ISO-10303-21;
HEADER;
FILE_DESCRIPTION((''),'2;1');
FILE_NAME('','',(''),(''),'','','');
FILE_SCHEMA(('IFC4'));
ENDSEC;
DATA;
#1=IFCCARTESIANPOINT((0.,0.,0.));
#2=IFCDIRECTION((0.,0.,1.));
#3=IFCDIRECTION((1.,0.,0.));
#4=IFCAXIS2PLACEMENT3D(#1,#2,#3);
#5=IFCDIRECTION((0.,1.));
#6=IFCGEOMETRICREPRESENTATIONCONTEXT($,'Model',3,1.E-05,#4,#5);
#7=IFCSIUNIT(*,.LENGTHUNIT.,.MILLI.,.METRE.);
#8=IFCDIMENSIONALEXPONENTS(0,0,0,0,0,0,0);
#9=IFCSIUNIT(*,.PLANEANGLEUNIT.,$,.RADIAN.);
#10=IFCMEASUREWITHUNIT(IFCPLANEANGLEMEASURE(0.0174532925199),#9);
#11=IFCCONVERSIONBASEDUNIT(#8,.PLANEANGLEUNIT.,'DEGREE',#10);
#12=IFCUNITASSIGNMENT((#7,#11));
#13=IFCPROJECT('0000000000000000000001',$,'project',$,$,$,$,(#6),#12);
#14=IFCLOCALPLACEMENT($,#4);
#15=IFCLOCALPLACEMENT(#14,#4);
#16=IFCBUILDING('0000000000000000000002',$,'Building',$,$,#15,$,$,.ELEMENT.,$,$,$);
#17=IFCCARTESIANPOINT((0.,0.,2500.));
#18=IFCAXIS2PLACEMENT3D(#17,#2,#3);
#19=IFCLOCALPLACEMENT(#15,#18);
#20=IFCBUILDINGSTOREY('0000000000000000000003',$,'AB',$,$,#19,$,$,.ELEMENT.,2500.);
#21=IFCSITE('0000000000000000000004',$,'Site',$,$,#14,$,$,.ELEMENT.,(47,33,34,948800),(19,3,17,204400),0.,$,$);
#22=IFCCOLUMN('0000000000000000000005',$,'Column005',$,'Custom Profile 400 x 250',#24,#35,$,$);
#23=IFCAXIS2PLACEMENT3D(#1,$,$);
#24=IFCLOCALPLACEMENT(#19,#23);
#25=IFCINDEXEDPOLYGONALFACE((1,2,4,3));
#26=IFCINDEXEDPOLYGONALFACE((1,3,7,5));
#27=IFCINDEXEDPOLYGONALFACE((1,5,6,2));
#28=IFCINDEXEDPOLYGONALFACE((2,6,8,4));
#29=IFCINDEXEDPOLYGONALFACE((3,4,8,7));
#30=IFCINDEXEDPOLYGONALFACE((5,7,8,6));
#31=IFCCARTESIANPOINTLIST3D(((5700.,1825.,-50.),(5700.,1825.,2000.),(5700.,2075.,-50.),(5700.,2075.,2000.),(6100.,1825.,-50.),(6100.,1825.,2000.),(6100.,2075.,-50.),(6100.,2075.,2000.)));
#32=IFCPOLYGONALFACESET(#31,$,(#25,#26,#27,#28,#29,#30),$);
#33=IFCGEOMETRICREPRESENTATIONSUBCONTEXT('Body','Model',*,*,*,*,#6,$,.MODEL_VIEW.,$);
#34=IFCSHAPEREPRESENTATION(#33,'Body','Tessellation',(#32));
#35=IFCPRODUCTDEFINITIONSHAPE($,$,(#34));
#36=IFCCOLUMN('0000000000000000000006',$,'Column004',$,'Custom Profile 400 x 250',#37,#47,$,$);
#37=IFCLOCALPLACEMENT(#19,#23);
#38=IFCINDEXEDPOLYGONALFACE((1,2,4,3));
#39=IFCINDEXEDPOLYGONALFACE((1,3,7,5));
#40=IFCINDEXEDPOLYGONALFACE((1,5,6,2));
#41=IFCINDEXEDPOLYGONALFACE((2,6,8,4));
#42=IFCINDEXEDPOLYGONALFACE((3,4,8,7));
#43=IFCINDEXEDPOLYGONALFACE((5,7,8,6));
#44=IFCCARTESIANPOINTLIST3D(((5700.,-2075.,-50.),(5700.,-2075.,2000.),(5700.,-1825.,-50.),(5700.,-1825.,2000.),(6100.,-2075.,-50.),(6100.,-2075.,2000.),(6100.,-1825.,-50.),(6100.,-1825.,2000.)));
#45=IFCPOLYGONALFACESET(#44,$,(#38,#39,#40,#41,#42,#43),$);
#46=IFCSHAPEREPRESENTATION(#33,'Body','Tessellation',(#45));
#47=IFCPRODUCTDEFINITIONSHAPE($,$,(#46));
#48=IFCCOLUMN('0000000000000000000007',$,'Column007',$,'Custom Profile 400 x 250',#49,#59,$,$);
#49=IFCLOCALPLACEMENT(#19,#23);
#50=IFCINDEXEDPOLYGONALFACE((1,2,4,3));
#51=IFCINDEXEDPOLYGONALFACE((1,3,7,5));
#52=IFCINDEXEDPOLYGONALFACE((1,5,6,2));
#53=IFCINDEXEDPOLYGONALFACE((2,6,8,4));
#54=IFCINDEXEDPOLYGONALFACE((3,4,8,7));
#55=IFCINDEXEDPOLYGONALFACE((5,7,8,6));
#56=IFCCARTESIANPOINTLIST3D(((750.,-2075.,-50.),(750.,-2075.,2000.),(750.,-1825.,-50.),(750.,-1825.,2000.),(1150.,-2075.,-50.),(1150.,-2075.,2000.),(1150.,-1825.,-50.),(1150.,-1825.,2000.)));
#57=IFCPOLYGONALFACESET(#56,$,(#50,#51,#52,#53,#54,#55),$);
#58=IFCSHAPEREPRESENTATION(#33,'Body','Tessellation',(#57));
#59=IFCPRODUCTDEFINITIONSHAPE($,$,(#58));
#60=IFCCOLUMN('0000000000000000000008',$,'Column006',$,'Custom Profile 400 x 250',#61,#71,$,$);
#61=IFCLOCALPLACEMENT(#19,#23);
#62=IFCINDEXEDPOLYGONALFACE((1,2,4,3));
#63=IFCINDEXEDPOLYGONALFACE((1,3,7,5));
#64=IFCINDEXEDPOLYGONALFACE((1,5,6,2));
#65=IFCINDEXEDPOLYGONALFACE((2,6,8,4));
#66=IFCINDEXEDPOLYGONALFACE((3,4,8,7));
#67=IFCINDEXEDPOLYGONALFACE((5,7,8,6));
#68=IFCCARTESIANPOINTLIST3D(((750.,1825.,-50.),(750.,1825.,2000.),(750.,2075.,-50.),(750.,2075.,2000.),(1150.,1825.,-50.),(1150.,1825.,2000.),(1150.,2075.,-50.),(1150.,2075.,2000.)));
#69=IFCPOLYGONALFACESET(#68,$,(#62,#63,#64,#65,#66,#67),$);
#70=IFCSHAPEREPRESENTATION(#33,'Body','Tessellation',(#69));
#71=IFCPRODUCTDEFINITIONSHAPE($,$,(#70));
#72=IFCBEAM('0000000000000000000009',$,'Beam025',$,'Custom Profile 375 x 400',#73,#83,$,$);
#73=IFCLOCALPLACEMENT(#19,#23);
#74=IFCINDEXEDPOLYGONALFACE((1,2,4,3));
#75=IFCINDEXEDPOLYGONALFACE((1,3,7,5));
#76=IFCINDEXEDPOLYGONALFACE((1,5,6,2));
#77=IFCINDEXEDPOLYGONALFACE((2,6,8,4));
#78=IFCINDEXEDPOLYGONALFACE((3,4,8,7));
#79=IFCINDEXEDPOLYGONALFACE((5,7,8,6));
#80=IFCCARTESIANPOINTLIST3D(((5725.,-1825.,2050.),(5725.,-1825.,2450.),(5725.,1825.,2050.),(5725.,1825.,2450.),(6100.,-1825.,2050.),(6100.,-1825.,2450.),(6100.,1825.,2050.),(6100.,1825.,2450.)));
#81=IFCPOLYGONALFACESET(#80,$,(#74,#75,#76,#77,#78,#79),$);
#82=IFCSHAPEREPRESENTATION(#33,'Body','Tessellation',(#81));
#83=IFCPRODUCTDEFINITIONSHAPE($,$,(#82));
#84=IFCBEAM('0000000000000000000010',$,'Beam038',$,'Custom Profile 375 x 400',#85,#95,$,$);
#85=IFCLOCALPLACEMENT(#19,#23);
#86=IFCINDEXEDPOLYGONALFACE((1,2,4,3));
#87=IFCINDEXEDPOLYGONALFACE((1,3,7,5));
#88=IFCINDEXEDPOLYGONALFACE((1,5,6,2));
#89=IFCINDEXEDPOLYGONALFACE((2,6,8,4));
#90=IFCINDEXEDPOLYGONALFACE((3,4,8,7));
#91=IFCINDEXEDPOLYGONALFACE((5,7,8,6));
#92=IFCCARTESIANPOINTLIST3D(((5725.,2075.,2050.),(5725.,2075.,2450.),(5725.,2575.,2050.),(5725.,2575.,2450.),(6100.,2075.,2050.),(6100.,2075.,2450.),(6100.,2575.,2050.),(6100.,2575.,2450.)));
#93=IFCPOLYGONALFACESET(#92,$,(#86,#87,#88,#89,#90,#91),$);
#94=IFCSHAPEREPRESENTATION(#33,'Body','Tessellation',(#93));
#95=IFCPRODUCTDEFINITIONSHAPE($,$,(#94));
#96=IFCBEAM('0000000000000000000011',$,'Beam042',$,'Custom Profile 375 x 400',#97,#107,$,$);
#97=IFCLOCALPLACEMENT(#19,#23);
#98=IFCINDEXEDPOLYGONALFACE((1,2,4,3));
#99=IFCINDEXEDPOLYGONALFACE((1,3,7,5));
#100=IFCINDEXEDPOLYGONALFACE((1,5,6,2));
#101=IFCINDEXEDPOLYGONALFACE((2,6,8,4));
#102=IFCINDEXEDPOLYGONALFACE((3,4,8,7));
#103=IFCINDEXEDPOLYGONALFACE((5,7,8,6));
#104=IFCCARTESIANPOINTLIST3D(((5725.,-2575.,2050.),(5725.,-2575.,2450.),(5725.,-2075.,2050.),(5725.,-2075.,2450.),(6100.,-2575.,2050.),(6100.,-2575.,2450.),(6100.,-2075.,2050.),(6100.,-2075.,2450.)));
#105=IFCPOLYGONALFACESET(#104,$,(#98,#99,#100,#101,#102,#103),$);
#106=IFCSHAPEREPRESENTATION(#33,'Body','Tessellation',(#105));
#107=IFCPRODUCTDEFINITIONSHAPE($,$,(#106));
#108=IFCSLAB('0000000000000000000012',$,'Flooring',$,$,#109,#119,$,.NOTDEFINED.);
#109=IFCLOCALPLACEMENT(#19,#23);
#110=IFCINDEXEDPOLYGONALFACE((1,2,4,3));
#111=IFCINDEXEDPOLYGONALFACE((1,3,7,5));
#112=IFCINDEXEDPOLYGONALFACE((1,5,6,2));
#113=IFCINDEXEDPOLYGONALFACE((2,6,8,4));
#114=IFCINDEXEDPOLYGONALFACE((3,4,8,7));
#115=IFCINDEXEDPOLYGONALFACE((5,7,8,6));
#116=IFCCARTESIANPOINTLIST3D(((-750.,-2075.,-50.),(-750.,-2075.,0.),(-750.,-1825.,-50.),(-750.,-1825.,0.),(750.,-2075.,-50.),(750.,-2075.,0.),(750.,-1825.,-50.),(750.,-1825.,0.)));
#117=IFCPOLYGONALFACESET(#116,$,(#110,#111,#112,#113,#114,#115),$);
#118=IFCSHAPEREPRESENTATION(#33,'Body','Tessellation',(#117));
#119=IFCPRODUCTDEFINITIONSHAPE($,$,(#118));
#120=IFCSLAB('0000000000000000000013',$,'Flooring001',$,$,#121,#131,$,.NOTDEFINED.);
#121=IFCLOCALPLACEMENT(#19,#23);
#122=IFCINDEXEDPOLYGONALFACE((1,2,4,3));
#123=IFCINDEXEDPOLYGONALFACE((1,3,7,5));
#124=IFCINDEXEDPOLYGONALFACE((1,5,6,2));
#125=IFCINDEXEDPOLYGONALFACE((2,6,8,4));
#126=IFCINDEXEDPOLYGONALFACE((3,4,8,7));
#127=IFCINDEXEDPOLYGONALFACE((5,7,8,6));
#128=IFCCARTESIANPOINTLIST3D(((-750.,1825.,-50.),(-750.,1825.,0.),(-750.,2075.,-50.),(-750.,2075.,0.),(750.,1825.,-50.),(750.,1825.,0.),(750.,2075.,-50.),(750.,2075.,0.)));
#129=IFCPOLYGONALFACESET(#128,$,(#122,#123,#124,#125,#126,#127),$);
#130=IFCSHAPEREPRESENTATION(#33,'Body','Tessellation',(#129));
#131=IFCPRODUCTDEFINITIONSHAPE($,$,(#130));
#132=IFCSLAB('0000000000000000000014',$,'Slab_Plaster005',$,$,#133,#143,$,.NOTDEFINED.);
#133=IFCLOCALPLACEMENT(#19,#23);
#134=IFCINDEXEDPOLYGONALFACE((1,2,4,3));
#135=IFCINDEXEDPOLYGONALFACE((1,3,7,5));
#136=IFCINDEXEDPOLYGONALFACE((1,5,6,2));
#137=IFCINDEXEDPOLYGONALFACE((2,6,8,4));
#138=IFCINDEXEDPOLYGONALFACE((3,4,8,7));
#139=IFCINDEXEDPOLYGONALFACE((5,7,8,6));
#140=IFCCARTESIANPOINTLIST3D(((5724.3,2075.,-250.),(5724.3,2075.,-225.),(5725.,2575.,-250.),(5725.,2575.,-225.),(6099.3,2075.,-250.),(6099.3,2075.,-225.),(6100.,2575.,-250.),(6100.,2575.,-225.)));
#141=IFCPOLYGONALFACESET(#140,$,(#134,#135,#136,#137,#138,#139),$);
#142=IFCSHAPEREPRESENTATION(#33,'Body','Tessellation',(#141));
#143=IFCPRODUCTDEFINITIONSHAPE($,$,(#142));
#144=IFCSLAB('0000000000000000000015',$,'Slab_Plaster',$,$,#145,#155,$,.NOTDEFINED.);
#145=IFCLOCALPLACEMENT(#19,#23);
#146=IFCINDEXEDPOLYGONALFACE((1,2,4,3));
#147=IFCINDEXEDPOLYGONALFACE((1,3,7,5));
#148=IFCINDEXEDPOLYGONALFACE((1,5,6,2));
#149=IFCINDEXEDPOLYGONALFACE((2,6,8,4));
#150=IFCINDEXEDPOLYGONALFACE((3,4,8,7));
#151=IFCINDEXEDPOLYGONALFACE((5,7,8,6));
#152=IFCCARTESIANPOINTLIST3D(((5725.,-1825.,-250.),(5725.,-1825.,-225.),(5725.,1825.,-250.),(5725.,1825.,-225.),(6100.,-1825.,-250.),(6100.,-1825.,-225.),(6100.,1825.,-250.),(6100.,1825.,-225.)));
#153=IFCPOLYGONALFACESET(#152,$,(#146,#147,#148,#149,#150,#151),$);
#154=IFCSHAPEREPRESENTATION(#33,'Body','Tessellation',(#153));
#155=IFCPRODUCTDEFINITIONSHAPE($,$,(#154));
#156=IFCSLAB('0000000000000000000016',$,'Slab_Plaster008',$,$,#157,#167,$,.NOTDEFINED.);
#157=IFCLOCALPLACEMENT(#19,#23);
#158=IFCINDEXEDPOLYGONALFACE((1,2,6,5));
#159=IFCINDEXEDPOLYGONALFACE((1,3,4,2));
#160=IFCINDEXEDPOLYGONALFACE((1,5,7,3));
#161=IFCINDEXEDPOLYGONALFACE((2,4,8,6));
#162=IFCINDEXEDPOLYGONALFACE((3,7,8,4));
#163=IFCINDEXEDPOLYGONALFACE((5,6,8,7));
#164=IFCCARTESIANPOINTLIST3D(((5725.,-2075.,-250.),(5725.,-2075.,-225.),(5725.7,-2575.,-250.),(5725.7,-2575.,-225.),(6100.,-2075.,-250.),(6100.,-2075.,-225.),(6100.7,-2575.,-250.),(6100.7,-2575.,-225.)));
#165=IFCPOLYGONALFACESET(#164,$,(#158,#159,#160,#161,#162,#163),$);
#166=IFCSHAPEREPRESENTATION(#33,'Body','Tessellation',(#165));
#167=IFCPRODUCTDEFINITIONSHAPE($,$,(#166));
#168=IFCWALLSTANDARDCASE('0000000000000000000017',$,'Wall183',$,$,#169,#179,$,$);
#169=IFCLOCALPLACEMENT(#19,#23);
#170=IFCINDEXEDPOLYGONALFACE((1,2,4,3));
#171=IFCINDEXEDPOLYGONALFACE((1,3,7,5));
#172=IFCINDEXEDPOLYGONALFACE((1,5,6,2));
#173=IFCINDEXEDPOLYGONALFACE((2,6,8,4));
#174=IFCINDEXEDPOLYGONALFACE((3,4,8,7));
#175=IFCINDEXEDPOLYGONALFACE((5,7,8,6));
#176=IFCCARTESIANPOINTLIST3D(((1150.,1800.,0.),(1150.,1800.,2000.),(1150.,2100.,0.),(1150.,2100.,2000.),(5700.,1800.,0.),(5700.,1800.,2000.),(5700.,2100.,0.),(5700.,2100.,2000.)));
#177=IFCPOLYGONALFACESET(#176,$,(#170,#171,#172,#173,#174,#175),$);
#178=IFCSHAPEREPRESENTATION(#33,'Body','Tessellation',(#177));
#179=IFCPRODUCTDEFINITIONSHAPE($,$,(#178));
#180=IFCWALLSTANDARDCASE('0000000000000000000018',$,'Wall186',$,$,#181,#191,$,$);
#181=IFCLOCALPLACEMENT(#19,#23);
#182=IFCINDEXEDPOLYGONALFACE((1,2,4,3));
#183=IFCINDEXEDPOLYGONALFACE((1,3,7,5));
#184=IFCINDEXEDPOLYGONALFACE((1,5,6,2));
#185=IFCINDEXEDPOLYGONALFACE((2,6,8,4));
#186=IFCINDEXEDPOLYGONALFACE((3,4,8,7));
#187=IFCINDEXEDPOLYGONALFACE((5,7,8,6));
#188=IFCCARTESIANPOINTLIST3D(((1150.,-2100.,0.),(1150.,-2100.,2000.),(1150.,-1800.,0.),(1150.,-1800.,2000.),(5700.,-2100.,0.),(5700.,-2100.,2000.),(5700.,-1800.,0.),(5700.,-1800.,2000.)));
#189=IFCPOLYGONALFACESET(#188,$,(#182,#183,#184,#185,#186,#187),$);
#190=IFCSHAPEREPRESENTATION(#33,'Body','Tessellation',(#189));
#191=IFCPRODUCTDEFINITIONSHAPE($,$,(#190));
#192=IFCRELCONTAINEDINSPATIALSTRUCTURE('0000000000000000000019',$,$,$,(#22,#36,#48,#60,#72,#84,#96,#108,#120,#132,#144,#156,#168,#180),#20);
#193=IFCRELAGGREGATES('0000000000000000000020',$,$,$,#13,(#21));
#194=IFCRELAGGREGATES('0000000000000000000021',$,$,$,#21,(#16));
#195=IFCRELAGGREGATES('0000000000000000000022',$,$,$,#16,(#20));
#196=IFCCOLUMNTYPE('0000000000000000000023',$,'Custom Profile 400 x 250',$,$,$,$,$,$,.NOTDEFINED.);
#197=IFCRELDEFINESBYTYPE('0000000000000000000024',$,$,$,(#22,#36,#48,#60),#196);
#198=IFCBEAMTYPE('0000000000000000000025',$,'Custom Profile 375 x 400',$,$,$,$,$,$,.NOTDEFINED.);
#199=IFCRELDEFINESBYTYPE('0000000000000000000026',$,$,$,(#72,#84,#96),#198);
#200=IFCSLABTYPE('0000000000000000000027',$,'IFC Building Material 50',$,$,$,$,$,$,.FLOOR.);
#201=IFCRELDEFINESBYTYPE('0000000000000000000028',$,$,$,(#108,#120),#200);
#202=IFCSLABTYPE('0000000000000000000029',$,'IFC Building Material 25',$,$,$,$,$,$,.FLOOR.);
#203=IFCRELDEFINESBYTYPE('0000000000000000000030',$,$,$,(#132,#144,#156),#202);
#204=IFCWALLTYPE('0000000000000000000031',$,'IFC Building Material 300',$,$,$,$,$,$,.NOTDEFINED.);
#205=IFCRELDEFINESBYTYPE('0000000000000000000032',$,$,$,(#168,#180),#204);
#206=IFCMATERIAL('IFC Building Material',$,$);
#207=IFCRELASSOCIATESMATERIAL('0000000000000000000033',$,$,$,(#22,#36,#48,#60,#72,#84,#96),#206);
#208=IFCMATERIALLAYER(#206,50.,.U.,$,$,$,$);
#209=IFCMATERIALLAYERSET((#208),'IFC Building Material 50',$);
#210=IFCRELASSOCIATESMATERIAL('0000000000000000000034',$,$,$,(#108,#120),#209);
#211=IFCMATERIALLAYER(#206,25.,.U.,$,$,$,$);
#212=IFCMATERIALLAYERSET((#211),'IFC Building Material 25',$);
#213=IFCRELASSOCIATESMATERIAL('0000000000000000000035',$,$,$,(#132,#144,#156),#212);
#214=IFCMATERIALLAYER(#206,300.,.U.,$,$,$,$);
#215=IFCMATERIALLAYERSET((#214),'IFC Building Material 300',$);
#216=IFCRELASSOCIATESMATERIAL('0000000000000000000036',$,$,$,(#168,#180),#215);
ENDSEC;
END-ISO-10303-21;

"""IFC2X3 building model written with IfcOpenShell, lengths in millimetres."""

from ifc_helpers import new_model, entity, si_unit, converted_unit, direction, frame, origin_with_axes, place, context, subcontext, project, spatial, polyline, outline, extrude, material, layer, layer_set, layer_usage, type_object, element, save


model = new_model("IFC2X3")

# Units and contexts
model_context = context("Model", 3, precision=1e-05, world=origin_with_axes(), true_north=direction((0.0, 1.0)))
body_context = subcontext(model_context, "Body", "Model", "MODEL_VIEW")
ifc_project = project(units=[si_unit("LENGTHUNIT", "METRE", prefix="MILLI"), converted_unit("PLANEANGLEUNIT", "DEGREE", entity("IfcPlaneAngleMeasure", 0.0174532925199), si_unit("PLANEANGLEUNIT", "RADIAN"), dimensions=[0, 0, 0, 0, 0, 0, 0])], contexts=[model_context])

# Site, building, storey
site_placement = place(None, origin_with_axes())
site = spatial("IfcSite", under=ifc_project, at=site_placement, Name="Site", CompositionType="ELEMENT", RefLatitude=(47, 33, 34, 948800), RefLongitude=(19, 3, 17, 204400), RefElevation=0.0)
building_placement = place(site_placement, origin_with_axes())
building = spatial("IfcBuilding", under=site, at=building_placement, Name="Building", CompositionType="ELEMENT")
storey_placement = place(building_placement, frame((0.0, 0.0, 2500.0), z_axis=(0.0, 0.0, 1.0), x_axis=(1.0, 0.0, 0.0)))
storey = spatial("IfcBuildingStorey", under=building, at=storey_placement, Name="AB", CompositionType="ELEMENT", Elevation=2500.0)

# Columns
ifc_material = material(Name="IFC Building Material")
column_type = type_object("IfcColumnType", Name="Custom Profile 400 x 250", PredefinedType="NOTDEFINED")
for number, where, z_axis, x_axis, name in (
    (1, (5900.0, 1950.0, -50.0), (0.0, 0.0, 1.0), (1.0, 0.0, 0.0), "Column005"),
    (2, (5900.0, -1950.0, -50.0), (0.0, 0.0, 1.0), (1.0, 0.0, 0.0), "Column004"),
    (3, (950.0, -1950.0, -50.0), (0.0, 0.0, 1.0), (1.0, 0.0, 0.0), "Column007"),
    (4, (950.0, 1950.0, -50.0), (0.0, 0.0, 1.0), (1.0, 0.0, 0.0), "Column006"),
):
    element("IfcColumn", number, at=place(storey_placement, frame(where, z_axis=z_axis, x_axis=x_axis)), inside=storey, type_object=column_type, material=ifc_material, Name=name, ObjectType="Custom Profile 400 x 250", context=body_context, shape_type="SweptSolid", body=[
        extrude(outline(polyline([(-200.0, -125.0), (200.0, -125.0), (200.0, 125.0), (-200.0, 125.0), (-200.0, -125.0)])), origin_with_axes(), (0.0, 0.0, 1.0), 2050.0),
    ])

# Beams
beam_type = type_object("IfcBeamType", Name="Custom Profile 375 x 400", PredefinedType="NOTDEFINED")
beam_placement = place(storey_placement, frame((5912.5, -1825.0, 2250.0), z_axis=(0.0, 0.0, 1.0), x_axis=(1.0, 0.0, 0.0)))
element("IfcBeam", 5, at=beam_placement, inside=storey, type_object=beam_type, material=ifc_material, Name="Beam025", ObjectType="Custom Profile 375 x 400", context=body_context, shape_type="SweptSolid", body=[
    extrude(outline(polyline([(-187.5, -200.0), (187.5, -200.0), (187.5, 200.0), (-187.5, 200.0), (-187.5, -200.0)])), frame((0.0, 3650.0, 0.0), z_axis=(0.0, -1.0, 0.0), x_axis=(1.0, 0.0, 0.0)), (0.0, 0.0, 1.0), 3650.0),
])
for number, where, z_axis, x_axis, name in (
    (6, (5912.5, 2575.0, 2250.0), (0.0, 0.0, 1.0), (-1.0, 0.0, 0.0), "Beam038"),
    (7, (5912.5, -2075.0, 2250.0), (0.0, 0.0, 1.0), (-1.0, 0.0, 0.0), "Beam042"),
):
    element("IfcBeam", number, at=place(storey_placement, frame(where, z_axis=z_axis, x_axis=x_axis)), inside=storey, type_object=beam_type, material=ifc_material, Name=name, ObjectType="Custom Profile 375 x 400", context=body_context, shape_type="SweptSolid", body=[
        extrude(outline(polyline([(187.5, 200.0), (-187.5, 200.0), (-187.5, -200.0), (187.5, -200.0), (187.5, 200.0)])), frame((0.0, 500.0, 0.0), z_axis=(0.0, -1.0, 0.0), x_axis=(1.0, 0.0, 0.0)), (0.0, 0.0, 1.0), 500.0),
    ])

# Slabs
ifc_layer_1 = layer(ifc_material, 50.0, ventilated="UNKNOWN")
ifc_layer_set_1 = layer_set([ifc_layer_1], Name="IFC Building Material 50")
ifc_layer_usage_1 = layer_usage(ifc_layer_set_1, "AXIS3", "NEGATIVE", 50.0)
slab_type_1 = type_object("IfcSlabType", Name="IFC Building Material 50", PredefinedType="FLOOR")
slab_1_placement = place(storey_placement, frame((-750.0, -2075.0, 0.0), z_axis=(0.0, 0.0, 1.0), x_axis=(1.0, 0.0, 0.0)))
element("IfcSlab", 8, at=slab_1_placement, inside=storey, type_object=slab_type_1, material=ifc_layer_usage_1, Name="Flooring", PredefinedType="NOTDEFINED", context=body_context, shape_type="SweptSolid", body=[
    extrude(outline(polyline([(0.0, 0.0), (1500.0, 0.0), (1500.0, 250.0), (0.0, 250.0), (0.0, 0.0)])), frame((0.0, 0.0, -50.0), z_axis=(0.0, 0.0, 1.0), x_axis=(1.0, 0.0, 0.0)), (0.0, 0.0, 1.0), 50.0),
])
ifc_layer_usage_2 = layer_usage(ifc_layer_set_1, "AXIS3", "NEGATIVE", 50.0)
slab_2_placement = place(storey_placement, frame((-750.0, 1825.0, 0.0), z_axis=(0.0, 0.0, 1.0), x_axis=(1.0, 0.0, 0.0)))
element("IfcSlab", 9, at=slab_2_placement, inside=storey, type_object=slab_type_1, material=ifc_layer_usage_2, Name="Flooring001", PredefinedType="NOTDEFINED", context=body_context, shape_type="SweptSolid", body=[
    extrude(outline(polyline([(0.0, 0.0), (1500.0, 0.0), (1500.0, 250.0), (0.0, 250.0), (0.0, 0.0)])), frame((0.0, 0.0, -50.0), z_axis=(0.0, 0.0, 1.0), x_axis=(1.0, 0.0, 0.0)), (0.0, 0.0, 1.0), 50.0),
])
ifc_layer_2 = layer(ifc_material, 25.0, ventilated="UNKNOWN")
ifc_layer_set_2 = layer_set([ifc_layer_2], Name="IFC Building Material 25")
ifc_layer_usage_3 = layer_usage(ifc_layer_set_2, "AXIS3", "NEGATIVE", 25.0)
slab_type_2 = type_object("IfcSlabType", Name="IFC Building Material 25", PredefinedType="FLOOR")
slab_3_placement = place(storey_placement, frame((6099.3, 2075.0, -225.0), z_axis=(0.0, 0.0, 1.0), x_axis=(1.0, 0.0, 0.0)))
element("IfcSlab", 10, at=slab_3_placement, inside=storey, type_object=slab_type_2, material=ifc_layer_usage_3, Name="Slab_Plaster005", PredefinedType="NOTDEFINED", context=body_context, shape_type="SweptSolid", body=[
    extrude(outline(polyline([(0.0, 0.0), (0.7, 500.0), (-374.3, 500.0), (-375.0, 0.0), (0.0, 0.0)])), frame((0.0, 0.0, -25.0), z_axis=(0.0, 0.0, 1.0), x_axis=(1.0, 0.0, 0.0)), (0.0, 0.0, 1.0), 25.0),
])
ifc_layer_usage_4 = layer_usage(ifc_layer_set_2, "AXIS3", "NEGATIVE", 25.0)
slab_4_placement = place(storey_placement, frame((6100.0, -1825.0, -225.0), z_axis=(0.0, 0.0, 1.0), x_axis=(1.0, 0.0, 0.0)))
element("IfcSlab", 11, at=slab_4_placement, inside=storey, type_object=slab_type_2, material=ifc_layer_usage_4, Name="Slab_Plaster", PredefinedType="NOTDEFINED", context=body_context, shape_type="SweptSolid", body=[
    extrude(outline(polyline([(0.0, 0.0), (0.0, 3650.0), (-375.0, 3650.0), (-375.0, 0.0), (0.0, 0.0)])), frame((0.0, 0.0, -25.0), z_axis=(0.0, 0.0, 1.0), x_axis=(1.0, 0.0, 0.0)), (0.0, 0.0, 1.0), 25.0),
])
ifc_layer_usage_5 = layer_usage(ifc_layer_set_2, "AXIS3", "NEGATIVE", 25.0)
slab_5_placement = place(storey_placement, frame((6100.0, -2075.0, -225.0), z_axis=(0.0, 0.0, 1.0), x_axis=(1.0, 0.0, 0.0)))
element("IfcSlab", 12, at=slab_5_placement, inside=storey, type_object=slab_type_2, material=ifc_layer_usage_5, Name="Slab_Plaster008", PredefinedType="NOTDEFINED", context=body_context, shape_type="SweptSolid", body=[
    extrude(outline(polyline([(0.0, 0.0), (-375.0, 0.0), (-374.3, -500.0), (0.7, -500.0), (0.0, 0.0)])), frame((0.0, 0.0, -25.0), z_axis=(0.0, 0.0, 1.0), x_axis=(1.0, 0.0, 0.0)), (0.0, 0.0, 1.0), 25.0),
])

# Walls
ifc_layer_3 = layer(ifc_material, 300.0, ventilated="UNKNOWN")
ifc_layer_set_3 = layer_set([ifc_layer_3], Name="IFC Building Material 300")
ifc_layer_usage_6 = layer_usage(ifc_layer_set_3, "AXIS2", "NEGATIVE", 300.0)
wall_type_1 = type_object("IfcWallType", Name="IFC Building Material 300", PredefinedType="NOTDEFINED")
wall_1_placement = place(storey_placement, frame((1150.0, 1800.0, 0.0), z_axis=(0.0, 0.0, 1.0), x_axis=(1.0, 0.0, 0.0)))
element("IfcWallStandardCase", 13, at=wall_1_placement, inside=storey, type_object=wall_type_1, material=ifc_layer_usage_6, Name="Wall183", context=body_context, shape_type="SweptSolid", body=[
    extrude(outline(polyline([(0.0, 0.0), (4550.0, 0.0), (4550.0, 300.0), (0.0, 300.0), (0.0, 0.0)])), origin_with_axes(), (0.0, 0.0, 1.0), 2000.0),
])
ifc_layer_usage_7 = layer_usage(ifc_layer_set_3, "AXIS2", "NEGATIVE", 0.0)
wall_2_placement = place(storey_placement, frame((1150.0, -1800.0, 0.0), z_axis=(0.0, 0.0, 1.0), x_axis=(1.0, 0.0, 0.0)))
element("IfcWallStandardCase", 14, at=wall_2_placement, inside=storey, type_object=wall_type_1, material=ifc_layer_usage_7, Name="Wall186", context=body_context, shape_type="SweptSolid", body=[
    extrude(outline(polyline([(0.0, -300.0), (4550.0, -300.0), (4550.0, 0.0), (0.0, 0.0), (0.0, -300.0)])), origin_with_axes(), (0.0, 0.0, 1.0), 2000.0),
])

save(model, "model.ifc")
